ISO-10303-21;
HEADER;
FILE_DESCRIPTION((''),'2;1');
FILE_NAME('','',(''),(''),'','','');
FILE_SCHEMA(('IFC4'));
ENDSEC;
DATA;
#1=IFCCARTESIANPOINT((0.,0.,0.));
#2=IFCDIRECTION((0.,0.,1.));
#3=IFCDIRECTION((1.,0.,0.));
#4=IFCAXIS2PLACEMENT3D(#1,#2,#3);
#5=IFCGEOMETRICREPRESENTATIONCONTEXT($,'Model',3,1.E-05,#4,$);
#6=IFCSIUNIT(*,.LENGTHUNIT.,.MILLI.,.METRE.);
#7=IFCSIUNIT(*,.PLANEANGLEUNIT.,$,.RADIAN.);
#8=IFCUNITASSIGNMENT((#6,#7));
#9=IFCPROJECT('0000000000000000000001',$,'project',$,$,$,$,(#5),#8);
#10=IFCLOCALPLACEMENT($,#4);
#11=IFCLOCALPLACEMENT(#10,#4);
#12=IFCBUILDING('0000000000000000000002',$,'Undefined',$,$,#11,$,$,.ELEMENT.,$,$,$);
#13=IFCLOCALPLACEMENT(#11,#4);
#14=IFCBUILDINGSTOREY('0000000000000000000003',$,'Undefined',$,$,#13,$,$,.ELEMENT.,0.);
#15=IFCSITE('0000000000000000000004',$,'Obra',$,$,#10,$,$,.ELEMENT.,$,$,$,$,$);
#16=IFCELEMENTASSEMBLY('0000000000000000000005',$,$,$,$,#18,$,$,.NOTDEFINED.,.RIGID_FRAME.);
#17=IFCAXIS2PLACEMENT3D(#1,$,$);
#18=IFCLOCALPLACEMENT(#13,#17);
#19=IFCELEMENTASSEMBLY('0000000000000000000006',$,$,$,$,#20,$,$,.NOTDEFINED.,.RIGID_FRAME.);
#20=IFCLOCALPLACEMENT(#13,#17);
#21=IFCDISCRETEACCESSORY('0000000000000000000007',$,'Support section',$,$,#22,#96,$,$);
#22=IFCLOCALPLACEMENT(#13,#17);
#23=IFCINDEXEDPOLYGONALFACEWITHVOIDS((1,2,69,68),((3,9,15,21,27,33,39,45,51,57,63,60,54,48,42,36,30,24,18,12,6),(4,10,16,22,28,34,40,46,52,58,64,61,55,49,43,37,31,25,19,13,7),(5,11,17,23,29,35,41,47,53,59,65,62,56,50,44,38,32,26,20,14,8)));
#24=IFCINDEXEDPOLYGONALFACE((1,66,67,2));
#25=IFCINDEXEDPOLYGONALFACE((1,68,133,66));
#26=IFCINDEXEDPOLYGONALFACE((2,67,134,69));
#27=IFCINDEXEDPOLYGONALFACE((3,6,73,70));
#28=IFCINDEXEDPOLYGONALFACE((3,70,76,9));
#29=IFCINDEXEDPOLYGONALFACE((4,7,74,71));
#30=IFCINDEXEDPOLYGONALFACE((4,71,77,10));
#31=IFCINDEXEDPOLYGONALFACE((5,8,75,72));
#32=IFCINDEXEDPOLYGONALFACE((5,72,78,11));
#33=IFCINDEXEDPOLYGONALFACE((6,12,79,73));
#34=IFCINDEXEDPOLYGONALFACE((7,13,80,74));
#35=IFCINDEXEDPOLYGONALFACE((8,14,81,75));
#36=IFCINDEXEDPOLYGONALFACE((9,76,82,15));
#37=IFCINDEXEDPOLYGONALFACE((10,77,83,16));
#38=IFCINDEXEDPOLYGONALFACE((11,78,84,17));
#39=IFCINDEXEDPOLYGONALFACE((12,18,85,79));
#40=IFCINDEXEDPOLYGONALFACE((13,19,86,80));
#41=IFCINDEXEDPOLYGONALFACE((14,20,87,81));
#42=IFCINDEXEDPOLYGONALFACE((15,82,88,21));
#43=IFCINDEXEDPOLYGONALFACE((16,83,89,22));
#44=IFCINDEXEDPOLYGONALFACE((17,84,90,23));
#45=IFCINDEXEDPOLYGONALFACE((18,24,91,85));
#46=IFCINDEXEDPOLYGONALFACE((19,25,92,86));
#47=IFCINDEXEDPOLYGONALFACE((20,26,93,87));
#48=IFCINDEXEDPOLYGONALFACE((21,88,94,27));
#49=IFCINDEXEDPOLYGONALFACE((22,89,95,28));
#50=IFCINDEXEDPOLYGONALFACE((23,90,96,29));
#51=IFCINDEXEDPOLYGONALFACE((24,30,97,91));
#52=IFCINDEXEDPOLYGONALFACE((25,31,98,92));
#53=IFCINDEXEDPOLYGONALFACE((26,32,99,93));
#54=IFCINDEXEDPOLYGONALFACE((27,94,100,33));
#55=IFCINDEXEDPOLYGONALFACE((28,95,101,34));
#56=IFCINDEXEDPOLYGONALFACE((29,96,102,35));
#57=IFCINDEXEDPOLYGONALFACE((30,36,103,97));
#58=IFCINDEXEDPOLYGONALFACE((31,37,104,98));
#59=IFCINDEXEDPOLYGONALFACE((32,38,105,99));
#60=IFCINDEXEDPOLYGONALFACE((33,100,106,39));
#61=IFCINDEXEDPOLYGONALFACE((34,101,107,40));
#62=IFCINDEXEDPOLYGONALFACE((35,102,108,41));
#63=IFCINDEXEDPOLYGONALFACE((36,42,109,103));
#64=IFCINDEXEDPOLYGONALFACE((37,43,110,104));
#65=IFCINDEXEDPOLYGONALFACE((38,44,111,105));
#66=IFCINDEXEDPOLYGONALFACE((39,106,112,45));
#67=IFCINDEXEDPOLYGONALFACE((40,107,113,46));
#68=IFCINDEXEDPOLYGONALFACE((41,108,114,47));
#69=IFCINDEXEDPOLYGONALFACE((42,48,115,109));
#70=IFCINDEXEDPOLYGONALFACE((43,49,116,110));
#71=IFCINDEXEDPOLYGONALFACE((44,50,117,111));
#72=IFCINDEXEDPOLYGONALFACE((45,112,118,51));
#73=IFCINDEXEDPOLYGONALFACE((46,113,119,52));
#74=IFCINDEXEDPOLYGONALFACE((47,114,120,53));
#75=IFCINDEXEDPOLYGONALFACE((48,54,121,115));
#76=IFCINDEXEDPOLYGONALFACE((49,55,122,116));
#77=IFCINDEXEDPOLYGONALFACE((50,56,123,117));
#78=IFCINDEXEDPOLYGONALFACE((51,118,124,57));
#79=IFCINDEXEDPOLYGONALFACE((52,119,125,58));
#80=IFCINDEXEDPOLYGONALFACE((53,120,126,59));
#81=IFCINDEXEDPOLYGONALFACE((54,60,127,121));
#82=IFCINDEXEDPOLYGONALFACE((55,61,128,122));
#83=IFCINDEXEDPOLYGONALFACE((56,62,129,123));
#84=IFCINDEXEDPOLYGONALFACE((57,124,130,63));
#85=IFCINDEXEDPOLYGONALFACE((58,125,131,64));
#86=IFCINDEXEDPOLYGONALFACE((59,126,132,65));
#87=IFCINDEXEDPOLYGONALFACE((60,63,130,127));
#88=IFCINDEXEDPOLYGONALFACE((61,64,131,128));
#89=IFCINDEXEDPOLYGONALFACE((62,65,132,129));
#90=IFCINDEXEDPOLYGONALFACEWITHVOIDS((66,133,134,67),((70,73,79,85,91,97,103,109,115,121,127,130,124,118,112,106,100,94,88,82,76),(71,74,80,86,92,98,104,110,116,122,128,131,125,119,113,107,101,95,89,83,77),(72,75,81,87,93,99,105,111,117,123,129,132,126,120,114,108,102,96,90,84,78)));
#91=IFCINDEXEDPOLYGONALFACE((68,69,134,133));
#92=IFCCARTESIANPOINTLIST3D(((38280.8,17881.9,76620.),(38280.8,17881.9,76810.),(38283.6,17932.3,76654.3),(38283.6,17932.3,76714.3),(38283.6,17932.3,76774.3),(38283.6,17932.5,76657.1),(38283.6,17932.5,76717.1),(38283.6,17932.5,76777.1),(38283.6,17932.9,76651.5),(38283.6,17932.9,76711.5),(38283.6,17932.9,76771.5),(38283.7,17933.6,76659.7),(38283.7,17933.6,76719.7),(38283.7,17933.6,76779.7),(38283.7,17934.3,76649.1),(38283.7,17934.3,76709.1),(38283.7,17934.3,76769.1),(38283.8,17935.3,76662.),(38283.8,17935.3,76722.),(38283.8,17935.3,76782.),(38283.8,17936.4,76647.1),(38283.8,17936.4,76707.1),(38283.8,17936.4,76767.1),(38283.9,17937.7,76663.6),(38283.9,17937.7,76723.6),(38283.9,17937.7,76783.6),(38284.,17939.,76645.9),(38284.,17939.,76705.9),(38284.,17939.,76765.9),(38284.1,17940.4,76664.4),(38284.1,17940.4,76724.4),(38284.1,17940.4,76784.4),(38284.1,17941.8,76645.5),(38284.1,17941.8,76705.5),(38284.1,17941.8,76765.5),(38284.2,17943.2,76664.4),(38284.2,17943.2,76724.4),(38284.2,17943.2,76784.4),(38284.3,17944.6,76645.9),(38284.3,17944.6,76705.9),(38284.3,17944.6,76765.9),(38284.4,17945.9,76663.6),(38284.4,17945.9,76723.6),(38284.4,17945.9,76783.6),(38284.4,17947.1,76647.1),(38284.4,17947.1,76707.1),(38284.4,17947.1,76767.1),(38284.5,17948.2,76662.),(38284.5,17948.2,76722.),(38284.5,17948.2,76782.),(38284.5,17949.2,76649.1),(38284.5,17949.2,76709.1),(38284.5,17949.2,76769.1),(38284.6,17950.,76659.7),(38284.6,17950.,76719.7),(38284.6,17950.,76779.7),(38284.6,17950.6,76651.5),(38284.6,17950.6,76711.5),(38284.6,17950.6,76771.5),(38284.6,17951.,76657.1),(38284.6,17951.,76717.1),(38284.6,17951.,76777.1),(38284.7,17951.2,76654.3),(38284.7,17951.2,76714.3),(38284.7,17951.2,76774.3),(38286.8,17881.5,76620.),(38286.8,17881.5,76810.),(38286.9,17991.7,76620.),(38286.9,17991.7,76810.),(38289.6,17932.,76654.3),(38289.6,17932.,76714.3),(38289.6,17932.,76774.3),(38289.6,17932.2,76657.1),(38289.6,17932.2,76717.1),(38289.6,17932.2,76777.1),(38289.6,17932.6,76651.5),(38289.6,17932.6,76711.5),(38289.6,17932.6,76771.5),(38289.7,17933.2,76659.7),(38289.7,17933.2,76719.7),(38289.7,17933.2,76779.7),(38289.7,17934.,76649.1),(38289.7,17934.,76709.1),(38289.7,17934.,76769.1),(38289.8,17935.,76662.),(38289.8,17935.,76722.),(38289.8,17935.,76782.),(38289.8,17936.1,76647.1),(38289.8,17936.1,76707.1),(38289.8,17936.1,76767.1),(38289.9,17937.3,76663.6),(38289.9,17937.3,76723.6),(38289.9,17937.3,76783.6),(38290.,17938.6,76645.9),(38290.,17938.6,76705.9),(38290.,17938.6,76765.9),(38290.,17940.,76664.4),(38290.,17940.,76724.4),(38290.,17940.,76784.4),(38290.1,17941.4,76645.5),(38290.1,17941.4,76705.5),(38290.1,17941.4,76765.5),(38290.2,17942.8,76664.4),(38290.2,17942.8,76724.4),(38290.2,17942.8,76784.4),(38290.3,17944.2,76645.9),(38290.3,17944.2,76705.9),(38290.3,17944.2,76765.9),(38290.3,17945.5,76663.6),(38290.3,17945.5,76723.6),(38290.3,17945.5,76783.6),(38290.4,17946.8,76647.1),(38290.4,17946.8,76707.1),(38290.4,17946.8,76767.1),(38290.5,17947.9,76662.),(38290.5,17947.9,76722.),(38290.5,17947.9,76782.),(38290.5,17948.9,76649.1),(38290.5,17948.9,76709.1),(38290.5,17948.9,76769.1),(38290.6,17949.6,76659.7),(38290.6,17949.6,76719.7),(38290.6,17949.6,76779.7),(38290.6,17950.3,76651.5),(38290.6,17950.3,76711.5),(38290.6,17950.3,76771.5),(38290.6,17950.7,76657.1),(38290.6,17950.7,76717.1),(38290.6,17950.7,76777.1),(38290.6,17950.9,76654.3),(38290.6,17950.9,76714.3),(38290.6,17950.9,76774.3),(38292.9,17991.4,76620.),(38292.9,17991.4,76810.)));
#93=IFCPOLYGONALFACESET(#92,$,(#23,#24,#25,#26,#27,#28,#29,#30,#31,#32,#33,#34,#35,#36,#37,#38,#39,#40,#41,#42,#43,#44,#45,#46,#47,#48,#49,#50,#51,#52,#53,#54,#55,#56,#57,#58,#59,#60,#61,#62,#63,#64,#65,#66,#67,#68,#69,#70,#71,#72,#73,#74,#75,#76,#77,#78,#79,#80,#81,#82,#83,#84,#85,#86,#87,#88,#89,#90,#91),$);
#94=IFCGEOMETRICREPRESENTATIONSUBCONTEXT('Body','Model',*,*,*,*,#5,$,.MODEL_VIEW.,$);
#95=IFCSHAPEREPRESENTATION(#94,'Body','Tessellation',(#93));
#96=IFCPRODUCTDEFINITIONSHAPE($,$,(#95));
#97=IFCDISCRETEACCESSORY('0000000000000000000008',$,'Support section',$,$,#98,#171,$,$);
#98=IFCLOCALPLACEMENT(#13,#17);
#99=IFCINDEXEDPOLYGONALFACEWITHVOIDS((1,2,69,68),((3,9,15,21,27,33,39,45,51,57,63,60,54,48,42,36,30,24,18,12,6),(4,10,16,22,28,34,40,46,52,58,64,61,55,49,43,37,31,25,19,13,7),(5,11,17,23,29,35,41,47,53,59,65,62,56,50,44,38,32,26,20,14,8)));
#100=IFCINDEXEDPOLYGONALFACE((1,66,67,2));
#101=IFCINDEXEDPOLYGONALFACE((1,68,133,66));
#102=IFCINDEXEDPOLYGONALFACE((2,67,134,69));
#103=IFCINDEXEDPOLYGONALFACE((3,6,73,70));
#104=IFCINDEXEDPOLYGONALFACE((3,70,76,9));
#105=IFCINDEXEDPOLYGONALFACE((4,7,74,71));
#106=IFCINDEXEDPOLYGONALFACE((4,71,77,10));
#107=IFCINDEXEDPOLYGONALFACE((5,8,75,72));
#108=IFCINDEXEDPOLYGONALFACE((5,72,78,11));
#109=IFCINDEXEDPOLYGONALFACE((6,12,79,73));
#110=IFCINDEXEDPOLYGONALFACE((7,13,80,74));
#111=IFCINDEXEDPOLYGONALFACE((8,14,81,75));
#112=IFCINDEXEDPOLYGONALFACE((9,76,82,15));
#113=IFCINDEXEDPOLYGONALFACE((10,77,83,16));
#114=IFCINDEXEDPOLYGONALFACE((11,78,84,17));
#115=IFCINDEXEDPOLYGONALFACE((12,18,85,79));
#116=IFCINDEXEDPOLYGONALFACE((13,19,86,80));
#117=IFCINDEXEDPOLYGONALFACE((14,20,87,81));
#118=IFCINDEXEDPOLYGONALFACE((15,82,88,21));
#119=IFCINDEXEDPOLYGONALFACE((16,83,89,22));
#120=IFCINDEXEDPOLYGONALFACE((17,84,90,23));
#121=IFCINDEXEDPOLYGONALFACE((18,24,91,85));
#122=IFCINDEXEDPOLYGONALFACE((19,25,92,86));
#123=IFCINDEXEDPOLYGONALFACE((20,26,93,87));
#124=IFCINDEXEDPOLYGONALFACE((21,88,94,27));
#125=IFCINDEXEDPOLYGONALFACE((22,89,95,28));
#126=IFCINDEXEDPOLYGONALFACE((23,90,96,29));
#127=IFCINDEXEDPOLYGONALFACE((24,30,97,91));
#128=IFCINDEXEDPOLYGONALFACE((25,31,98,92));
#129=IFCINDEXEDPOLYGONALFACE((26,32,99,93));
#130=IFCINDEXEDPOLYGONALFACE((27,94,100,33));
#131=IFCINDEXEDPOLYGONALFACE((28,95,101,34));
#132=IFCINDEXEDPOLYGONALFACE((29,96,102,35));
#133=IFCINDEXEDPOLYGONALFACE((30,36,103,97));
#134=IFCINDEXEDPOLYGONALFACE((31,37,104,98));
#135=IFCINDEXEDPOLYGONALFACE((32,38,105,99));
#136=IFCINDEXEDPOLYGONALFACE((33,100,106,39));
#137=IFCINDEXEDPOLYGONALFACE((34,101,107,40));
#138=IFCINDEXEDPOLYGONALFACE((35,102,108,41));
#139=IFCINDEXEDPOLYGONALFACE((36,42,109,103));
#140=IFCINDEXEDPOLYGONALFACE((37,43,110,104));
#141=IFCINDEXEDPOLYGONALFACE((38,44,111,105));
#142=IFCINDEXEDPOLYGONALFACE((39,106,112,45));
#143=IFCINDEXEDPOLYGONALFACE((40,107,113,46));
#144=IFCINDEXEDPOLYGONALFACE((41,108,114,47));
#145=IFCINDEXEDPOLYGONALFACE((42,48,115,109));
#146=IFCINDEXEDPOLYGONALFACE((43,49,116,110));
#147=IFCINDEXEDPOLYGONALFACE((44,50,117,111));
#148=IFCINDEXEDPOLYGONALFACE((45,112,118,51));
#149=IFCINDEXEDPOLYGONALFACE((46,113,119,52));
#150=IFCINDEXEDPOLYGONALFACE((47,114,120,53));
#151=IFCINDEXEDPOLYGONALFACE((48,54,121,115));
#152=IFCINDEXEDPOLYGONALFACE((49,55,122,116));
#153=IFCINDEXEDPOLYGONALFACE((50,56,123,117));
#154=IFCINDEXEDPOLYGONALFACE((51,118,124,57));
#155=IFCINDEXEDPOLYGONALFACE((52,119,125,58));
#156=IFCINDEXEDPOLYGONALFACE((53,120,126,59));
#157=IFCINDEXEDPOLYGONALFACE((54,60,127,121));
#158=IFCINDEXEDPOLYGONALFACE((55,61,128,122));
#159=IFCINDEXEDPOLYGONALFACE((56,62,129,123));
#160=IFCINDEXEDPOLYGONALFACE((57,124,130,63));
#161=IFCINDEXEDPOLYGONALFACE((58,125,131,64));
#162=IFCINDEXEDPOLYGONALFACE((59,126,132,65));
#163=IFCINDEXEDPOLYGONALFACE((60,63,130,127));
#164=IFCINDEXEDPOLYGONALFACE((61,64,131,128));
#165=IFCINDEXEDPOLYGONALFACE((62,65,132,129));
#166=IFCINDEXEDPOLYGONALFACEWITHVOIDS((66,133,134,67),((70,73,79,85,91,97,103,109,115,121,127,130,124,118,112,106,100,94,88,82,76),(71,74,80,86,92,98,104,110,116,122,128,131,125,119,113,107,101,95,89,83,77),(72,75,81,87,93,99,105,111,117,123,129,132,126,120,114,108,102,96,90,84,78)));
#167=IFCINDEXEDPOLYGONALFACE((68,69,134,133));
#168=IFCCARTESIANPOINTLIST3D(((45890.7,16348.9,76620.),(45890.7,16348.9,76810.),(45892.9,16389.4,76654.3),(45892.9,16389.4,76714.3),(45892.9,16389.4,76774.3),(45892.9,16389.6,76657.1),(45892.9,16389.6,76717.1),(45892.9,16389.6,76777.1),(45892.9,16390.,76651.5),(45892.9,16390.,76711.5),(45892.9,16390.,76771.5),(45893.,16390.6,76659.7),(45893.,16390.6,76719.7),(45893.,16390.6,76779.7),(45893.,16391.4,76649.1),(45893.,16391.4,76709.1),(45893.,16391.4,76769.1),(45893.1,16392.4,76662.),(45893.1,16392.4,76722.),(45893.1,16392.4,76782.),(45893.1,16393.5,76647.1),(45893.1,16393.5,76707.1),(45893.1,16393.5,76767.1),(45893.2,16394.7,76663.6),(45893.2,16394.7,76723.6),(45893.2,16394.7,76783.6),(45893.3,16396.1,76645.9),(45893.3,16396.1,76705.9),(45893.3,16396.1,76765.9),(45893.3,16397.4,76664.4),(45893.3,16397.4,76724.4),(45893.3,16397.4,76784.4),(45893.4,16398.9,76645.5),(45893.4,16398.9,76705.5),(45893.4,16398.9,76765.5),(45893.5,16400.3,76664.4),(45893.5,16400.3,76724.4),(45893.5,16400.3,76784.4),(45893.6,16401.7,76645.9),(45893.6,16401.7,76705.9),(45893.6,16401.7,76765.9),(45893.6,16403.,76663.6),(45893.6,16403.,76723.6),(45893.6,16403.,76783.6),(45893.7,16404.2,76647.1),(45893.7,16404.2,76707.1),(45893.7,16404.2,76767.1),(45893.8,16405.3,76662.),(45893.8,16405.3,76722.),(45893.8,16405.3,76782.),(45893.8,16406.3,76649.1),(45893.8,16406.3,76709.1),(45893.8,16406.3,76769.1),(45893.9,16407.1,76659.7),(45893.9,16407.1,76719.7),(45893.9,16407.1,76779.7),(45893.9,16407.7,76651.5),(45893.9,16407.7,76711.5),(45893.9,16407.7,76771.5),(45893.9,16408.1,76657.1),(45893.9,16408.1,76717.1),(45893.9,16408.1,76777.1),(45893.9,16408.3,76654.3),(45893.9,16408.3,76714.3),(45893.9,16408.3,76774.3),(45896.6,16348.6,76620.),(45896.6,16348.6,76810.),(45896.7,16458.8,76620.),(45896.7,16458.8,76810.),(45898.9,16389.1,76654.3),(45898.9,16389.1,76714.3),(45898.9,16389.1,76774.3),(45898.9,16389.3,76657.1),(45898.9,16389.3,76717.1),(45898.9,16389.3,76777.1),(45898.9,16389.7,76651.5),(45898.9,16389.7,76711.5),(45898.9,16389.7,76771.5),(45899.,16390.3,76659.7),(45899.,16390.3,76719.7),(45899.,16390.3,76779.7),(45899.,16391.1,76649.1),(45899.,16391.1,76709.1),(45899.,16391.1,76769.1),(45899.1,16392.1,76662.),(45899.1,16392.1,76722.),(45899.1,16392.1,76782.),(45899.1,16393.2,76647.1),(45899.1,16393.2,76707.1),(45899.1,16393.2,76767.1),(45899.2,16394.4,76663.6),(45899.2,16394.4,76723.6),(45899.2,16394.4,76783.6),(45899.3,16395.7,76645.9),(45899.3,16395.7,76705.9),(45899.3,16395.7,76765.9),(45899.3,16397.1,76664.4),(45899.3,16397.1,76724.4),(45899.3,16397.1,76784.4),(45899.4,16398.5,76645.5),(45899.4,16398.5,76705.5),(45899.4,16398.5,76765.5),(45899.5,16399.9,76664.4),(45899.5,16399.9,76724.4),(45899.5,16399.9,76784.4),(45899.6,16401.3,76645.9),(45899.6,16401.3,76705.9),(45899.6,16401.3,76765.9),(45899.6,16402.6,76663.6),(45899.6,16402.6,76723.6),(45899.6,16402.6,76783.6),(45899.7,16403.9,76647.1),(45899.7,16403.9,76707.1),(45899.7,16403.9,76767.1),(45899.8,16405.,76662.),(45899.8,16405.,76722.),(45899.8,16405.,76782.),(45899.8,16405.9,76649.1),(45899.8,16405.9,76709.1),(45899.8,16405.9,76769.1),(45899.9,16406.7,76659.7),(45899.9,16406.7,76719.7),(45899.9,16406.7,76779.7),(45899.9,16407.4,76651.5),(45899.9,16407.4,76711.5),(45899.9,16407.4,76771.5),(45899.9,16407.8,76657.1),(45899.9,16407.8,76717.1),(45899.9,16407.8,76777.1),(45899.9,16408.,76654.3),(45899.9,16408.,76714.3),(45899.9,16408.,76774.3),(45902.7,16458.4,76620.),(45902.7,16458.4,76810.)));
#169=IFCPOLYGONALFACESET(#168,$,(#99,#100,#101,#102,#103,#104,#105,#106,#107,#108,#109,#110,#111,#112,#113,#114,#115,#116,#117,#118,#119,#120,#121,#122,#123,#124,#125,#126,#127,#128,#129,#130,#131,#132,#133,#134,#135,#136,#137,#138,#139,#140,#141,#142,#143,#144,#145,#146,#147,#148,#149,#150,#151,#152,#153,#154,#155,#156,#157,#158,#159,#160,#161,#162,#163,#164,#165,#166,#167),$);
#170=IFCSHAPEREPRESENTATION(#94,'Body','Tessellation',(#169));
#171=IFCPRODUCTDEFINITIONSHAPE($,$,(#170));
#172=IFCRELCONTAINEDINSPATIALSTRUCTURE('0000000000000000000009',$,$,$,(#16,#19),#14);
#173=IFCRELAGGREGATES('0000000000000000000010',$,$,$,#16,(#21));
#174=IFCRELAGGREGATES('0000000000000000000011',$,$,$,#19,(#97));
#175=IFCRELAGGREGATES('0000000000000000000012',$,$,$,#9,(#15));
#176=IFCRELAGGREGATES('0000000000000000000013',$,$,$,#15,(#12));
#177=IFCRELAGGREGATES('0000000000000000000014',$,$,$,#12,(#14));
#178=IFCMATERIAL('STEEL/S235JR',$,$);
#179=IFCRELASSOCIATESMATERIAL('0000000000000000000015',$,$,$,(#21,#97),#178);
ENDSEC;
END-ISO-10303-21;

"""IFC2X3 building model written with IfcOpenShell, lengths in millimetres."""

from ifc_helpers import new_model, si_unit, frame, origin_with_axes, origin_2d_with_axis, place, context, subcontext, project, spatial, rectangle, circle, extrude, source, transform, mapped, material, element, aggregate, save


model = new_model("IFC2X3")

# Units and contexts
model_context = context("Model", 3, precision=1e-05, world=origin_with_axes())
body_context = subcontext(model_context, "Body", "Model", "MODEL_VIEW")
ifc_project = project(units=[si_unit("LENGTHUNIT", "METRE", prefix="MILLI"), si_unit("PLANEANGLEUNIT", "RADIAN")], contexts=[model_context])

# Site, building, storey
site_placement = place(None, origin_with_axes())
site = spatial("IfcSite", under=ifc_project, at=site_placement, Name="Obra", CompositionType="ELEMENT")
building_placement = place(site_placement, origin_with_axes())
building = spatial("IfcBuilding", under=site, at=building_placement, Name="Undefined", CompositionType="ELEMENT")
storey_placement = place(building_placement, origin_with_axes())
storey = spatial("IfcBuildingStorey", under=building, at=storey_placement, Name="Undefined", CompositionType="ELEMENT", Elevation=0.0)

# Element assemblies
ifc_material_1 = material(Name="STEEL/S235JR")
assembly_1_placement = place(storey_placement, origin_with_axes())
assembly_1 = element("IfcElementAssembly", 1, at=assembly_1_placement, inside=storey, AssemblyPlace="NOTDEFINED", PredefinedType="RIGID_FRAME")
assembly_2_placement = place(storey_placement, origin_with_axes())
assembly_2 = element("IfcElementAssembly", 2, at=assembly_2_placement, inside=storey, AssemblyPlace="NOTDEFINED", PredefinedType="RIGID_FRAME")

# Discrete accessories, openings
shared_shape = source(origin_with_axes(), body_context, "Body", "SweptSolid", [
    extrude(circle(Radius=9.5, at=origin_2d_with_axis()), frame((0.0, -9.2, 0.0), z_axis=(0.0, 1.0, 0.0), x_axis=(1.0, 0.0, 0.0)), (0.0, 0.0, 1.0), 6.2),
])
discrete_accessory_1_placement = place(assembly_1_placement, frame((38286.9, 17936.6, 76620.0), z_axis=(0.0, 0.0, 1.0), x_axis=(-0.055268, -0.998472, 0.0)))
discrete_accessory_1 = element("IfcDiscreteAccessory", 3, at=discrete_accessory_1_placement, material=ifc_material_1, Name="Support section", context=body_context, shape_type="SweptSolid", body=[
    extrude(rectangle(XDim=6.0, YDim=110.0, at=origin_2d_with_axis()), frame((0.0, 0.0, 190.0), z_axis=(0.0, 0.0, -1.0), x_axis=(0.0, 1.0, 0.0)), (0.0, 0.0, 1.0), 190.0),
])
opening_1_placement = place(assembly_1_placement, frame((38278.3, 17892.0, 76835.0), z_axis=(0.055268, 0.998472, 0.0), x_axis=(0.0, 0.0, -1.0)))
element("IfcOpeningElement", 4, at=opening_1_placement, cuts=discrete_accessory_1, ObjectType="Opening", context=body_context, shape_type="MappedRepresentation", body=[
    mapped(shared_shape, transform((60.0, 0.0, 50.0))),
    mapped(shared_shape, transform((120.0, 0.0, 50.0))),
    mapped(shared_shape, transform((180.0, 0.0, 50.0))),
])
aggregate(assembly_1, [discrete_accessory_1])
discrete_accessory_2_placement = place(assembly_2_placement, frame((45896.7, 16403.7, 76620.0), z_axis=(0.0, 0.0, 1.0), x_axis=(0.055268, 0.998472, 0.0)))
discrete_accessory_2 = element("IfcDiscreteAccessory", 5, at=discrete_accessory_2_placement, material=ifc_material_1, Name="Support section", context=body_context, shape_type="SweptSolid", body=[
    extrude(rectangle(XDim=6.0, YDim=110.0, at=origin_2d_with_axis()), frame((0.0, 0.0, 190.0), z_axis=(0.0, 0.0, -1.0), x_axis=(0.0, 1.0, 0.0)), (0.0, 0.0, 1.0), 190.0),
])
opening_2_placement = place(assembly_2_placement, frame((45905.3, 16448.3, 76835.0), z_axis=(-0.055268, -0.998472, 0.0), x_axis=(0.0, 0.0, -1.0)))
element("IfcOpeningElement", 6, at=opening_2_placement, cuts=discrete_accessory_2, ObjectType="Opening", context=body_context, shape_type="MappedRepresentation", body=[
    mapped(shared_shape, transform((60.0, 0.0, 50.0))),
    mapped(shared_shape, transform((120.0, 0.0, 50.0))),
    mapped(shared_shape, transform((180.0, 0.0, 50.0))),
])
aggregate(assembly_2, [discrete_accessory_2])

save(model, "model.ifc")
